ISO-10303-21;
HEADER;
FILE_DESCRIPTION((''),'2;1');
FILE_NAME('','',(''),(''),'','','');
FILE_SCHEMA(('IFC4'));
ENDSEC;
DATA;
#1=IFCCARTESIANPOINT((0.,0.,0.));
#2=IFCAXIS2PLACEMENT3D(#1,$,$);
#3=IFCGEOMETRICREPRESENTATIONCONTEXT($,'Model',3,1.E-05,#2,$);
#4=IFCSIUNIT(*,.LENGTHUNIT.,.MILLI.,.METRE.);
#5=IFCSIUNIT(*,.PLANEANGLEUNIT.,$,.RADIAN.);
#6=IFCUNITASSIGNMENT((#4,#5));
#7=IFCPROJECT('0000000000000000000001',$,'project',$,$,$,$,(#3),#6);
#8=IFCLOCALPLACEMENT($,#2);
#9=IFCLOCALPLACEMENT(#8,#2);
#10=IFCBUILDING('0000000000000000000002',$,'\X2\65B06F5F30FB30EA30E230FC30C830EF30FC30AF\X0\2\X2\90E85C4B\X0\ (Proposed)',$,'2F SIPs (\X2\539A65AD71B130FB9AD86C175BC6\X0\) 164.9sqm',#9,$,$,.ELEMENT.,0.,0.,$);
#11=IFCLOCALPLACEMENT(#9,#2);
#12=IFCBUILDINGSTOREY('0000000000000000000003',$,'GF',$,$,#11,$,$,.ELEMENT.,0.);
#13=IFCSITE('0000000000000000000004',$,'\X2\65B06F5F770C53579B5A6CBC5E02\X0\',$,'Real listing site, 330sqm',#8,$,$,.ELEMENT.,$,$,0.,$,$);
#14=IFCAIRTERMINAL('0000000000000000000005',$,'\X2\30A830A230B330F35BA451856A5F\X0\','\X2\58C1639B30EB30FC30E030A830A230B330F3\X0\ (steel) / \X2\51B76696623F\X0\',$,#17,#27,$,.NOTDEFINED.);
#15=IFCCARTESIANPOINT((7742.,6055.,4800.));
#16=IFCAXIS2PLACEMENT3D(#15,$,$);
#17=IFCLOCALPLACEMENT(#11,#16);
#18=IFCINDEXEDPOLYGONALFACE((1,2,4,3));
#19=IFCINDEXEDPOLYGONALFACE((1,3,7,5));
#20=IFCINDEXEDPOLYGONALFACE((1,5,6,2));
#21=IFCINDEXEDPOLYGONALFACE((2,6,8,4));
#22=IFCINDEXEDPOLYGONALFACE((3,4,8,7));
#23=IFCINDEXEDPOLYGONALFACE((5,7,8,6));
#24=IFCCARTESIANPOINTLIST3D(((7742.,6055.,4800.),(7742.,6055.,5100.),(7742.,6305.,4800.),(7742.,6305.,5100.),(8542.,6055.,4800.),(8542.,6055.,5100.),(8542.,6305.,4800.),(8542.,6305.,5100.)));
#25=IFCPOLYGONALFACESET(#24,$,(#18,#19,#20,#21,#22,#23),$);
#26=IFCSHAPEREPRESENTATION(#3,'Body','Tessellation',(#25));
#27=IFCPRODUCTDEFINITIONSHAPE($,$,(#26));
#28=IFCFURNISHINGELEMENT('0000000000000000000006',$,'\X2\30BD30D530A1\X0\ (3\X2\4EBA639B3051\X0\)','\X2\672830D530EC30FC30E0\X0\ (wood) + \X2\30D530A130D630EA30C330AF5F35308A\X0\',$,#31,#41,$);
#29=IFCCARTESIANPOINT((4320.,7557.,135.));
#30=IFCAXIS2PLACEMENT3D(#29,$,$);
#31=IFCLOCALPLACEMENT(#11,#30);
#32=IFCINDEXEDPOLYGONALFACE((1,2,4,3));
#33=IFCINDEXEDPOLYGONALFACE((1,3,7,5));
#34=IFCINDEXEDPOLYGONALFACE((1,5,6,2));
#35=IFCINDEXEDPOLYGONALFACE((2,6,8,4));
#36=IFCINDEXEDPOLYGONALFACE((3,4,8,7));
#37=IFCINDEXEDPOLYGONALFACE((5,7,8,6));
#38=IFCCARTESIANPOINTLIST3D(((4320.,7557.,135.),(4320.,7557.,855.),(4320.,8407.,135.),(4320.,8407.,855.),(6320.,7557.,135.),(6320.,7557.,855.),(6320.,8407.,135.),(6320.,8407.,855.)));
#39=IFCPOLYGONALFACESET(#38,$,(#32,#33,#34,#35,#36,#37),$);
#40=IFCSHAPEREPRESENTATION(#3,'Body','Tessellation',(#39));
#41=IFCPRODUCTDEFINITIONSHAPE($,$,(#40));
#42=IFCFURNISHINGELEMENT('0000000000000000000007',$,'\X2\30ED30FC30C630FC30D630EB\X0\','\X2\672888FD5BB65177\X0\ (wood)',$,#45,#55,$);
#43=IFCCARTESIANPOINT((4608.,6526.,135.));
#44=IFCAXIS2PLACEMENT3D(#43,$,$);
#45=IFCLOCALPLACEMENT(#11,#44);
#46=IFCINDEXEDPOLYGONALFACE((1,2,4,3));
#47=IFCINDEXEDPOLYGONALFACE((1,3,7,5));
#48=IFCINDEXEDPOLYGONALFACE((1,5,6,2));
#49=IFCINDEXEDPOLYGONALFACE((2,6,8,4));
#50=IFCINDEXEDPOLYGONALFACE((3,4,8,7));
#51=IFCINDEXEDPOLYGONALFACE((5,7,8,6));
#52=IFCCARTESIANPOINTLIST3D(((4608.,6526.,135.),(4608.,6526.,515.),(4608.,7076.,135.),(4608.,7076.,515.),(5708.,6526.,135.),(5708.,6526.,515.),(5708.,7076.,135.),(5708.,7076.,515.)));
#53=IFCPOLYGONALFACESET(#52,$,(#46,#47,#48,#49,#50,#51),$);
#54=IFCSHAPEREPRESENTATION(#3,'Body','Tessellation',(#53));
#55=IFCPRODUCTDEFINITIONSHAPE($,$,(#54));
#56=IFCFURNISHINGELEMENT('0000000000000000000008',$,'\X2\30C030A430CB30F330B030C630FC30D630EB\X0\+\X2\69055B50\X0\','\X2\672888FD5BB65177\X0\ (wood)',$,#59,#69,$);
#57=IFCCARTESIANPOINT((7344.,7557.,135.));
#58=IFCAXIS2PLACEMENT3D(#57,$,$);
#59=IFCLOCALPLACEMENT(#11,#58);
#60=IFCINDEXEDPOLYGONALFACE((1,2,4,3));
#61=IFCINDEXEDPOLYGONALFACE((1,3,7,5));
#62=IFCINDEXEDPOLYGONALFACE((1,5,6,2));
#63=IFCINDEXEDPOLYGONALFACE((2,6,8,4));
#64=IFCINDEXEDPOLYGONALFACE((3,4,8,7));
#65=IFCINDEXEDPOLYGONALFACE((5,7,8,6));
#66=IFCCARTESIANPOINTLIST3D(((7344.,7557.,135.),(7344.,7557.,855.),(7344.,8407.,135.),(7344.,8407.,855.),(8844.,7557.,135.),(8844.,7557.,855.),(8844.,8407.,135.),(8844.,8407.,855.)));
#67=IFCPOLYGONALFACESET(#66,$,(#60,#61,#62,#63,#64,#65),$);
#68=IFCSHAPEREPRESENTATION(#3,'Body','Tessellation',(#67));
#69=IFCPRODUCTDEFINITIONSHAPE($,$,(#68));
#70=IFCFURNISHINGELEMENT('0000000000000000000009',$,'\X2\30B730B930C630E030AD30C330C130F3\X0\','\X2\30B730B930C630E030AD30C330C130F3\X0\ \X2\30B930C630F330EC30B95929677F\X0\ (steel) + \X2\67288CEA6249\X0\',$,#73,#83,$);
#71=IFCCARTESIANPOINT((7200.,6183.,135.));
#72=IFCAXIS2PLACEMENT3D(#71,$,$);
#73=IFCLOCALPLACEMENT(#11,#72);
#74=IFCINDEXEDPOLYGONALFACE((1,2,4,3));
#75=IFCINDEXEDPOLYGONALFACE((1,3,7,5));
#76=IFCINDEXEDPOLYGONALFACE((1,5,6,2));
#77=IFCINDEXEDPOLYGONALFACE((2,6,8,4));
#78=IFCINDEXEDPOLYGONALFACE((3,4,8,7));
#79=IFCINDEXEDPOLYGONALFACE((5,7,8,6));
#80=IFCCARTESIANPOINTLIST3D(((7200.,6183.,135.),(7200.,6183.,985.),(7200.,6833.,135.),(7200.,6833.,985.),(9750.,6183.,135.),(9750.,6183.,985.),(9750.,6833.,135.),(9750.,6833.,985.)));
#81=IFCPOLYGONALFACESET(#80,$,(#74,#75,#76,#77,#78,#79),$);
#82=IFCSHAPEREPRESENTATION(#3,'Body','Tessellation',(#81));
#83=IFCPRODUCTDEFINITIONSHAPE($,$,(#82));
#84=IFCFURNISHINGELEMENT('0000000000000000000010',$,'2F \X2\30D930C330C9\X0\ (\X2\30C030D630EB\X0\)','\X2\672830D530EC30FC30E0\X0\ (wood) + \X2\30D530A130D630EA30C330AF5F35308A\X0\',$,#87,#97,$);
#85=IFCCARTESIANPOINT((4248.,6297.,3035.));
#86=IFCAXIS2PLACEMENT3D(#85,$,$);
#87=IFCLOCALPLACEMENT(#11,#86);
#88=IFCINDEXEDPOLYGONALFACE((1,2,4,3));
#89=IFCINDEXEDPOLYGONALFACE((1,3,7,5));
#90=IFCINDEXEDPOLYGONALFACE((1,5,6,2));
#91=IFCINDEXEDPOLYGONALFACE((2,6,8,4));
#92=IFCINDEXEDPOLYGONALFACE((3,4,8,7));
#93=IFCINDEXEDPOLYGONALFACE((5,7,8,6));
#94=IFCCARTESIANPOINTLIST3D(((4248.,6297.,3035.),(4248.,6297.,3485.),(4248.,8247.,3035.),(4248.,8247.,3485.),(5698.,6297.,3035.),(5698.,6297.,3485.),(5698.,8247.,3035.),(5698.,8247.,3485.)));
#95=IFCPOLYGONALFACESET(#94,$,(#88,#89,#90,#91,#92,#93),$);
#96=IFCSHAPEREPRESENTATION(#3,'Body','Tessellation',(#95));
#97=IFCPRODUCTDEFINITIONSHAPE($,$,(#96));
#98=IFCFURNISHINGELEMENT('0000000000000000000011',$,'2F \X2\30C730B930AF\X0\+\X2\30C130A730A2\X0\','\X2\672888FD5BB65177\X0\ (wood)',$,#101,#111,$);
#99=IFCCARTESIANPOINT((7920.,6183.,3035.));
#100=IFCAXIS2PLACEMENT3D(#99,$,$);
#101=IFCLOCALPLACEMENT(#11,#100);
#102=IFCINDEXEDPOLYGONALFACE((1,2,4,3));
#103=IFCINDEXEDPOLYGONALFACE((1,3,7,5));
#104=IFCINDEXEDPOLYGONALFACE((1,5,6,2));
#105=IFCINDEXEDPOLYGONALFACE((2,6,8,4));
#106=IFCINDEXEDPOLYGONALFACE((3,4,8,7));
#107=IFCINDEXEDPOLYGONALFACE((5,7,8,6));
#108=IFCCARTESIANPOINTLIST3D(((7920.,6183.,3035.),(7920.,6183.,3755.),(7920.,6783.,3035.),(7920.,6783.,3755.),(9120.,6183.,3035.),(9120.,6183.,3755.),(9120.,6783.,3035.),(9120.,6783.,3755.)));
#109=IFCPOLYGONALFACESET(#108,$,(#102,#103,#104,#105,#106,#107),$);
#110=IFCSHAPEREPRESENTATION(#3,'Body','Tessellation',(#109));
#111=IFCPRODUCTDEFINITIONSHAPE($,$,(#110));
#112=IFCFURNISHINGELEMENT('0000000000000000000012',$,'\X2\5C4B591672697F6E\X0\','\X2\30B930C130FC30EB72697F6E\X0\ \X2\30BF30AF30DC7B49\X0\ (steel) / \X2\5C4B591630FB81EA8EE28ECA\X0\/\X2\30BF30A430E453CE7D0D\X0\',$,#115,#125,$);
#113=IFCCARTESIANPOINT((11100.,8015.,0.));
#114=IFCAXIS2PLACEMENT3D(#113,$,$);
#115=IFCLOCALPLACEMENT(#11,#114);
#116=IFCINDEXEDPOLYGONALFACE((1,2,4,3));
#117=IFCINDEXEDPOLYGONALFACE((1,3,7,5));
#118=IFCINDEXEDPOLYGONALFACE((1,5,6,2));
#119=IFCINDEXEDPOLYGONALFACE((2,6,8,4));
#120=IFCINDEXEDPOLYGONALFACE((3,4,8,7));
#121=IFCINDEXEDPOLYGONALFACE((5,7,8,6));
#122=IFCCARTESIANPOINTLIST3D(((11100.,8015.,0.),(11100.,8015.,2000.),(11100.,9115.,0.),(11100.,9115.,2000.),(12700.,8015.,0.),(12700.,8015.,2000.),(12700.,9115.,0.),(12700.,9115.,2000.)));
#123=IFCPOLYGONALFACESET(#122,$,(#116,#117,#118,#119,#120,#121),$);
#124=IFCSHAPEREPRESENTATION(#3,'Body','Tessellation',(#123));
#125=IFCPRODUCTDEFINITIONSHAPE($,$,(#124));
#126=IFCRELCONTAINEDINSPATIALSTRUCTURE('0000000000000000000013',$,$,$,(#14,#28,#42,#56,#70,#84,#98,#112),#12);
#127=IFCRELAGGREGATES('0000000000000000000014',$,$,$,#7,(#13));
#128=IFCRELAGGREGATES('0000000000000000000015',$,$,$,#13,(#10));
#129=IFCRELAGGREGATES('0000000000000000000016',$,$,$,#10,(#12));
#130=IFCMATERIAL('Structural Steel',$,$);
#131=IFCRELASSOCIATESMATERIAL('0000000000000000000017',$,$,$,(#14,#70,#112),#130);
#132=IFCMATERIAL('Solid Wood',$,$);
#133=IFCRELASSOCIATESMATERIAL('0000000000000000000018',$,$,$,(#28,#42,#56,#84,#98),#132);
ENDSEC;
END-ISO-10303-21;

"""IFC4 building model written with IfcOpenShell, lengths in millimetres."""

from ifc_helpers import new_model, si_unit, frame, frame_2d, origin, place, context, project, spatial, rectangle, extrude, material, element, save


model = new_model("IFC4")

# Units and contexts
model_context = context("Model", 3, precision=1e-05, world=origin())
ifc_project = project(units=[si_unit("LENGTHUNIT", "METRE", prefix="MILLI"), si_unit("PLANEANGLEUNIT", "RADIAN")], contexts=[model_context])

# Site, building, storey
site_placement = place(None, origin())
site = spatial("IfcSite", under=ifc_project, at=site_placement, Name="新潟県南魚沼市", ObjectType="Real listing site, 330sqm", CompositionType="ELEMENT", RefElevation=0.0)
building_placement = place(site_placement, origin())
building = spatial("IfcBuilding", under=site, at=building_placement, Name="新潟・リモートワーク2部屋 (Proposed)", ObjectType="2F SIPs (厚断熱・高気密) 164.9sqm", CompositionType="ELEMENT", ElevationOfRefHeight=0.0, ElevationOfTerrain=0.0)
storey_placement = place(building_placement, origin())
storey = spatial("IfcBuildingStorey", under=building, at=storey_placement, Name="GF", CompositionType="ELEMENT", Elevation=0.0)

# Shared definitions
ifc_material_1 = material(Name="Solid Wood")

# Shared definitions
ifc_material_2 = material(Name="Structural Steel")

# Air terminal
air_terminal_1_placement = place(storey_placement, frame((7742.0, 6055.0, 4800.0)))
element("IfcAirTerminal", 1, at=air_terminal_1_placement, inside=storey, material=ifc_material_2, Name="エアコン室内機", Description="壁掛ルームエアコン (steel) / 冷暖房", PredefinedType="NOTDEFINED", context=model_context, shape_type="SweptSolid", body=[
    extrude(rectangle(XDim=800.0, YDim=250.0, at=frame_2d((400.0, 125.0))), frame((7742.0, 6055.0, 4800.0)), (0.0, 0.0, 1.0), 300.0),
])

# Furnishing elements
furnishing_1_placement = place(storey_placement, frame((4320.0, 7557.0, 135.0)))
element("IfcFurnishingElement", 2, at=furnishing_1_placement, inside=storey, material=ifc_material_1, Name="ソファ (3人掛け)", Description="木フレーム (wood) + ファブリック張り", context=model_context, shape_type="SweptSolid", body=[
    extrude(rectangle(XDim=2000.0, YDim=850.0, at=frame_2d((1000.0, 425.0))), frame((4320.0, 7557.0, 135.0)), (0.0, 0.0, 1.0), 720.0),
])
furnishing_2_placement = place(storey_placement, frame((4608.0, 6526.0, 135.0)))
element("IfcFurnishingElement", 3, at=furnishing_2_placement, inside=storey, material=ifc_material_1, Name="ローテーブル", Description="木製家具 (wood)", context=model_context, shape_type="SweptSolid", body=[
    extrude(rectangle(XDim=1100.0, YDim=550.0, at=frame_2d((550.0, 275.0))), frame((4608.0, 6526.0, 135.0)), (0.0, 0.0, 1.0), 380.0),
])
furnishing_3_placement = place(storey_placement, frame((7344.0, 7557.0, 135.0)))
element("IfcFurnishingElement", 4, at=furnishing_3_placement, inside=storey, material=ifc_material_1, Name="ダイニングテーブル+椅子", Description="木製家具 (wood)", context=model_context, shape_type="SweptSolid", body=[
    extrude(rectangle(XDim=1500.0, YDim=850.0, at=frame_2d((750.0, 425.0))), frame((7344.0, 7557.0, 135.0)), (0.0, 0.0, 1.0), 720.0),
])
furnishing_4_placement = place(storey_placement, frame((7200.0, 6183.0, 135.0)))
element("IfcFurnishingElement", 5, at=furnishing_4_placement, inside=storey, material=ifc_material_2, Name="システムキッチン", Description="システムキッチン ステンレス天板 (steel) + 木質扉", context=model_context, shape_type="SweptSolid", body=[
    extrude(rectangle(XDim=2550.0, YDim=650.0, at=frame_2d((1275.0, 325.0))), frame((7200.0, 6183.0, 135.0)), (0.0, 0.0, 1.0), 850.0),
])
furnishing_5_placement = place(storey_placement, frame((4248.0, 6297.0, 3035.0)))
element("IfcFurnishingElement", 6, at=furnishing_5_placement, inside=storey, material=ifc_material_1, Name="2F ベッド (ダブル)", Description="木フレーム (wood) + ファブリック張り", context=model_context, shape_type="SweptSolid", body=[
    extrude(rectangle(XDim=1450.0, YDim=1950.0, at=frame_2d((725.0, 975.0))), frame((4248.0, 6297.0, 3035.0)), (0.0, 0.0, 1.0), 450.0),
])
furnishing_6_placement = place(storey_placement, frame((7920.0, 6183.0, 3035.0)))
element("IfcFurnishingElement", 7, at=furnishing_6_placement, inside=storey, material=ifc_material_1, Name="2F デスク+チェア", Description="木製家具 (wood)", context=model_context, shape_type="SweptSolid", body=[
    extrude(rectangle(XDim=1200.0, YDim=600.0, at=frame_2d((600.0, 300.0))), frame((7920.0, 6183.0, 3035.0)), (0.0, 0.0, 1.0), 720.0),
])
furnishing_7_placement = place(storey_placement, frame((11100.0, 8015.0, 0.0)))
element("IfcFurnishingElement", 8, at=furnishing_7_placement, inside=storey, material=ifc_material_2, Name="屋外物置", Description="スチール物置 タクボ等 (steel) / 屋外・自転車/タイヤ収納", context=model_context, shape_type="SweptSolid", body=[
    extrude(rectangle(XDim=1600.0, YDim=1100.0, at=frame_2d((800.0, 550.0))), frame((11100.0, 8015.0, 0.0)), (0.0, 0.0, 1.0), 2000.0),
])

save(model, "model.ifc")
